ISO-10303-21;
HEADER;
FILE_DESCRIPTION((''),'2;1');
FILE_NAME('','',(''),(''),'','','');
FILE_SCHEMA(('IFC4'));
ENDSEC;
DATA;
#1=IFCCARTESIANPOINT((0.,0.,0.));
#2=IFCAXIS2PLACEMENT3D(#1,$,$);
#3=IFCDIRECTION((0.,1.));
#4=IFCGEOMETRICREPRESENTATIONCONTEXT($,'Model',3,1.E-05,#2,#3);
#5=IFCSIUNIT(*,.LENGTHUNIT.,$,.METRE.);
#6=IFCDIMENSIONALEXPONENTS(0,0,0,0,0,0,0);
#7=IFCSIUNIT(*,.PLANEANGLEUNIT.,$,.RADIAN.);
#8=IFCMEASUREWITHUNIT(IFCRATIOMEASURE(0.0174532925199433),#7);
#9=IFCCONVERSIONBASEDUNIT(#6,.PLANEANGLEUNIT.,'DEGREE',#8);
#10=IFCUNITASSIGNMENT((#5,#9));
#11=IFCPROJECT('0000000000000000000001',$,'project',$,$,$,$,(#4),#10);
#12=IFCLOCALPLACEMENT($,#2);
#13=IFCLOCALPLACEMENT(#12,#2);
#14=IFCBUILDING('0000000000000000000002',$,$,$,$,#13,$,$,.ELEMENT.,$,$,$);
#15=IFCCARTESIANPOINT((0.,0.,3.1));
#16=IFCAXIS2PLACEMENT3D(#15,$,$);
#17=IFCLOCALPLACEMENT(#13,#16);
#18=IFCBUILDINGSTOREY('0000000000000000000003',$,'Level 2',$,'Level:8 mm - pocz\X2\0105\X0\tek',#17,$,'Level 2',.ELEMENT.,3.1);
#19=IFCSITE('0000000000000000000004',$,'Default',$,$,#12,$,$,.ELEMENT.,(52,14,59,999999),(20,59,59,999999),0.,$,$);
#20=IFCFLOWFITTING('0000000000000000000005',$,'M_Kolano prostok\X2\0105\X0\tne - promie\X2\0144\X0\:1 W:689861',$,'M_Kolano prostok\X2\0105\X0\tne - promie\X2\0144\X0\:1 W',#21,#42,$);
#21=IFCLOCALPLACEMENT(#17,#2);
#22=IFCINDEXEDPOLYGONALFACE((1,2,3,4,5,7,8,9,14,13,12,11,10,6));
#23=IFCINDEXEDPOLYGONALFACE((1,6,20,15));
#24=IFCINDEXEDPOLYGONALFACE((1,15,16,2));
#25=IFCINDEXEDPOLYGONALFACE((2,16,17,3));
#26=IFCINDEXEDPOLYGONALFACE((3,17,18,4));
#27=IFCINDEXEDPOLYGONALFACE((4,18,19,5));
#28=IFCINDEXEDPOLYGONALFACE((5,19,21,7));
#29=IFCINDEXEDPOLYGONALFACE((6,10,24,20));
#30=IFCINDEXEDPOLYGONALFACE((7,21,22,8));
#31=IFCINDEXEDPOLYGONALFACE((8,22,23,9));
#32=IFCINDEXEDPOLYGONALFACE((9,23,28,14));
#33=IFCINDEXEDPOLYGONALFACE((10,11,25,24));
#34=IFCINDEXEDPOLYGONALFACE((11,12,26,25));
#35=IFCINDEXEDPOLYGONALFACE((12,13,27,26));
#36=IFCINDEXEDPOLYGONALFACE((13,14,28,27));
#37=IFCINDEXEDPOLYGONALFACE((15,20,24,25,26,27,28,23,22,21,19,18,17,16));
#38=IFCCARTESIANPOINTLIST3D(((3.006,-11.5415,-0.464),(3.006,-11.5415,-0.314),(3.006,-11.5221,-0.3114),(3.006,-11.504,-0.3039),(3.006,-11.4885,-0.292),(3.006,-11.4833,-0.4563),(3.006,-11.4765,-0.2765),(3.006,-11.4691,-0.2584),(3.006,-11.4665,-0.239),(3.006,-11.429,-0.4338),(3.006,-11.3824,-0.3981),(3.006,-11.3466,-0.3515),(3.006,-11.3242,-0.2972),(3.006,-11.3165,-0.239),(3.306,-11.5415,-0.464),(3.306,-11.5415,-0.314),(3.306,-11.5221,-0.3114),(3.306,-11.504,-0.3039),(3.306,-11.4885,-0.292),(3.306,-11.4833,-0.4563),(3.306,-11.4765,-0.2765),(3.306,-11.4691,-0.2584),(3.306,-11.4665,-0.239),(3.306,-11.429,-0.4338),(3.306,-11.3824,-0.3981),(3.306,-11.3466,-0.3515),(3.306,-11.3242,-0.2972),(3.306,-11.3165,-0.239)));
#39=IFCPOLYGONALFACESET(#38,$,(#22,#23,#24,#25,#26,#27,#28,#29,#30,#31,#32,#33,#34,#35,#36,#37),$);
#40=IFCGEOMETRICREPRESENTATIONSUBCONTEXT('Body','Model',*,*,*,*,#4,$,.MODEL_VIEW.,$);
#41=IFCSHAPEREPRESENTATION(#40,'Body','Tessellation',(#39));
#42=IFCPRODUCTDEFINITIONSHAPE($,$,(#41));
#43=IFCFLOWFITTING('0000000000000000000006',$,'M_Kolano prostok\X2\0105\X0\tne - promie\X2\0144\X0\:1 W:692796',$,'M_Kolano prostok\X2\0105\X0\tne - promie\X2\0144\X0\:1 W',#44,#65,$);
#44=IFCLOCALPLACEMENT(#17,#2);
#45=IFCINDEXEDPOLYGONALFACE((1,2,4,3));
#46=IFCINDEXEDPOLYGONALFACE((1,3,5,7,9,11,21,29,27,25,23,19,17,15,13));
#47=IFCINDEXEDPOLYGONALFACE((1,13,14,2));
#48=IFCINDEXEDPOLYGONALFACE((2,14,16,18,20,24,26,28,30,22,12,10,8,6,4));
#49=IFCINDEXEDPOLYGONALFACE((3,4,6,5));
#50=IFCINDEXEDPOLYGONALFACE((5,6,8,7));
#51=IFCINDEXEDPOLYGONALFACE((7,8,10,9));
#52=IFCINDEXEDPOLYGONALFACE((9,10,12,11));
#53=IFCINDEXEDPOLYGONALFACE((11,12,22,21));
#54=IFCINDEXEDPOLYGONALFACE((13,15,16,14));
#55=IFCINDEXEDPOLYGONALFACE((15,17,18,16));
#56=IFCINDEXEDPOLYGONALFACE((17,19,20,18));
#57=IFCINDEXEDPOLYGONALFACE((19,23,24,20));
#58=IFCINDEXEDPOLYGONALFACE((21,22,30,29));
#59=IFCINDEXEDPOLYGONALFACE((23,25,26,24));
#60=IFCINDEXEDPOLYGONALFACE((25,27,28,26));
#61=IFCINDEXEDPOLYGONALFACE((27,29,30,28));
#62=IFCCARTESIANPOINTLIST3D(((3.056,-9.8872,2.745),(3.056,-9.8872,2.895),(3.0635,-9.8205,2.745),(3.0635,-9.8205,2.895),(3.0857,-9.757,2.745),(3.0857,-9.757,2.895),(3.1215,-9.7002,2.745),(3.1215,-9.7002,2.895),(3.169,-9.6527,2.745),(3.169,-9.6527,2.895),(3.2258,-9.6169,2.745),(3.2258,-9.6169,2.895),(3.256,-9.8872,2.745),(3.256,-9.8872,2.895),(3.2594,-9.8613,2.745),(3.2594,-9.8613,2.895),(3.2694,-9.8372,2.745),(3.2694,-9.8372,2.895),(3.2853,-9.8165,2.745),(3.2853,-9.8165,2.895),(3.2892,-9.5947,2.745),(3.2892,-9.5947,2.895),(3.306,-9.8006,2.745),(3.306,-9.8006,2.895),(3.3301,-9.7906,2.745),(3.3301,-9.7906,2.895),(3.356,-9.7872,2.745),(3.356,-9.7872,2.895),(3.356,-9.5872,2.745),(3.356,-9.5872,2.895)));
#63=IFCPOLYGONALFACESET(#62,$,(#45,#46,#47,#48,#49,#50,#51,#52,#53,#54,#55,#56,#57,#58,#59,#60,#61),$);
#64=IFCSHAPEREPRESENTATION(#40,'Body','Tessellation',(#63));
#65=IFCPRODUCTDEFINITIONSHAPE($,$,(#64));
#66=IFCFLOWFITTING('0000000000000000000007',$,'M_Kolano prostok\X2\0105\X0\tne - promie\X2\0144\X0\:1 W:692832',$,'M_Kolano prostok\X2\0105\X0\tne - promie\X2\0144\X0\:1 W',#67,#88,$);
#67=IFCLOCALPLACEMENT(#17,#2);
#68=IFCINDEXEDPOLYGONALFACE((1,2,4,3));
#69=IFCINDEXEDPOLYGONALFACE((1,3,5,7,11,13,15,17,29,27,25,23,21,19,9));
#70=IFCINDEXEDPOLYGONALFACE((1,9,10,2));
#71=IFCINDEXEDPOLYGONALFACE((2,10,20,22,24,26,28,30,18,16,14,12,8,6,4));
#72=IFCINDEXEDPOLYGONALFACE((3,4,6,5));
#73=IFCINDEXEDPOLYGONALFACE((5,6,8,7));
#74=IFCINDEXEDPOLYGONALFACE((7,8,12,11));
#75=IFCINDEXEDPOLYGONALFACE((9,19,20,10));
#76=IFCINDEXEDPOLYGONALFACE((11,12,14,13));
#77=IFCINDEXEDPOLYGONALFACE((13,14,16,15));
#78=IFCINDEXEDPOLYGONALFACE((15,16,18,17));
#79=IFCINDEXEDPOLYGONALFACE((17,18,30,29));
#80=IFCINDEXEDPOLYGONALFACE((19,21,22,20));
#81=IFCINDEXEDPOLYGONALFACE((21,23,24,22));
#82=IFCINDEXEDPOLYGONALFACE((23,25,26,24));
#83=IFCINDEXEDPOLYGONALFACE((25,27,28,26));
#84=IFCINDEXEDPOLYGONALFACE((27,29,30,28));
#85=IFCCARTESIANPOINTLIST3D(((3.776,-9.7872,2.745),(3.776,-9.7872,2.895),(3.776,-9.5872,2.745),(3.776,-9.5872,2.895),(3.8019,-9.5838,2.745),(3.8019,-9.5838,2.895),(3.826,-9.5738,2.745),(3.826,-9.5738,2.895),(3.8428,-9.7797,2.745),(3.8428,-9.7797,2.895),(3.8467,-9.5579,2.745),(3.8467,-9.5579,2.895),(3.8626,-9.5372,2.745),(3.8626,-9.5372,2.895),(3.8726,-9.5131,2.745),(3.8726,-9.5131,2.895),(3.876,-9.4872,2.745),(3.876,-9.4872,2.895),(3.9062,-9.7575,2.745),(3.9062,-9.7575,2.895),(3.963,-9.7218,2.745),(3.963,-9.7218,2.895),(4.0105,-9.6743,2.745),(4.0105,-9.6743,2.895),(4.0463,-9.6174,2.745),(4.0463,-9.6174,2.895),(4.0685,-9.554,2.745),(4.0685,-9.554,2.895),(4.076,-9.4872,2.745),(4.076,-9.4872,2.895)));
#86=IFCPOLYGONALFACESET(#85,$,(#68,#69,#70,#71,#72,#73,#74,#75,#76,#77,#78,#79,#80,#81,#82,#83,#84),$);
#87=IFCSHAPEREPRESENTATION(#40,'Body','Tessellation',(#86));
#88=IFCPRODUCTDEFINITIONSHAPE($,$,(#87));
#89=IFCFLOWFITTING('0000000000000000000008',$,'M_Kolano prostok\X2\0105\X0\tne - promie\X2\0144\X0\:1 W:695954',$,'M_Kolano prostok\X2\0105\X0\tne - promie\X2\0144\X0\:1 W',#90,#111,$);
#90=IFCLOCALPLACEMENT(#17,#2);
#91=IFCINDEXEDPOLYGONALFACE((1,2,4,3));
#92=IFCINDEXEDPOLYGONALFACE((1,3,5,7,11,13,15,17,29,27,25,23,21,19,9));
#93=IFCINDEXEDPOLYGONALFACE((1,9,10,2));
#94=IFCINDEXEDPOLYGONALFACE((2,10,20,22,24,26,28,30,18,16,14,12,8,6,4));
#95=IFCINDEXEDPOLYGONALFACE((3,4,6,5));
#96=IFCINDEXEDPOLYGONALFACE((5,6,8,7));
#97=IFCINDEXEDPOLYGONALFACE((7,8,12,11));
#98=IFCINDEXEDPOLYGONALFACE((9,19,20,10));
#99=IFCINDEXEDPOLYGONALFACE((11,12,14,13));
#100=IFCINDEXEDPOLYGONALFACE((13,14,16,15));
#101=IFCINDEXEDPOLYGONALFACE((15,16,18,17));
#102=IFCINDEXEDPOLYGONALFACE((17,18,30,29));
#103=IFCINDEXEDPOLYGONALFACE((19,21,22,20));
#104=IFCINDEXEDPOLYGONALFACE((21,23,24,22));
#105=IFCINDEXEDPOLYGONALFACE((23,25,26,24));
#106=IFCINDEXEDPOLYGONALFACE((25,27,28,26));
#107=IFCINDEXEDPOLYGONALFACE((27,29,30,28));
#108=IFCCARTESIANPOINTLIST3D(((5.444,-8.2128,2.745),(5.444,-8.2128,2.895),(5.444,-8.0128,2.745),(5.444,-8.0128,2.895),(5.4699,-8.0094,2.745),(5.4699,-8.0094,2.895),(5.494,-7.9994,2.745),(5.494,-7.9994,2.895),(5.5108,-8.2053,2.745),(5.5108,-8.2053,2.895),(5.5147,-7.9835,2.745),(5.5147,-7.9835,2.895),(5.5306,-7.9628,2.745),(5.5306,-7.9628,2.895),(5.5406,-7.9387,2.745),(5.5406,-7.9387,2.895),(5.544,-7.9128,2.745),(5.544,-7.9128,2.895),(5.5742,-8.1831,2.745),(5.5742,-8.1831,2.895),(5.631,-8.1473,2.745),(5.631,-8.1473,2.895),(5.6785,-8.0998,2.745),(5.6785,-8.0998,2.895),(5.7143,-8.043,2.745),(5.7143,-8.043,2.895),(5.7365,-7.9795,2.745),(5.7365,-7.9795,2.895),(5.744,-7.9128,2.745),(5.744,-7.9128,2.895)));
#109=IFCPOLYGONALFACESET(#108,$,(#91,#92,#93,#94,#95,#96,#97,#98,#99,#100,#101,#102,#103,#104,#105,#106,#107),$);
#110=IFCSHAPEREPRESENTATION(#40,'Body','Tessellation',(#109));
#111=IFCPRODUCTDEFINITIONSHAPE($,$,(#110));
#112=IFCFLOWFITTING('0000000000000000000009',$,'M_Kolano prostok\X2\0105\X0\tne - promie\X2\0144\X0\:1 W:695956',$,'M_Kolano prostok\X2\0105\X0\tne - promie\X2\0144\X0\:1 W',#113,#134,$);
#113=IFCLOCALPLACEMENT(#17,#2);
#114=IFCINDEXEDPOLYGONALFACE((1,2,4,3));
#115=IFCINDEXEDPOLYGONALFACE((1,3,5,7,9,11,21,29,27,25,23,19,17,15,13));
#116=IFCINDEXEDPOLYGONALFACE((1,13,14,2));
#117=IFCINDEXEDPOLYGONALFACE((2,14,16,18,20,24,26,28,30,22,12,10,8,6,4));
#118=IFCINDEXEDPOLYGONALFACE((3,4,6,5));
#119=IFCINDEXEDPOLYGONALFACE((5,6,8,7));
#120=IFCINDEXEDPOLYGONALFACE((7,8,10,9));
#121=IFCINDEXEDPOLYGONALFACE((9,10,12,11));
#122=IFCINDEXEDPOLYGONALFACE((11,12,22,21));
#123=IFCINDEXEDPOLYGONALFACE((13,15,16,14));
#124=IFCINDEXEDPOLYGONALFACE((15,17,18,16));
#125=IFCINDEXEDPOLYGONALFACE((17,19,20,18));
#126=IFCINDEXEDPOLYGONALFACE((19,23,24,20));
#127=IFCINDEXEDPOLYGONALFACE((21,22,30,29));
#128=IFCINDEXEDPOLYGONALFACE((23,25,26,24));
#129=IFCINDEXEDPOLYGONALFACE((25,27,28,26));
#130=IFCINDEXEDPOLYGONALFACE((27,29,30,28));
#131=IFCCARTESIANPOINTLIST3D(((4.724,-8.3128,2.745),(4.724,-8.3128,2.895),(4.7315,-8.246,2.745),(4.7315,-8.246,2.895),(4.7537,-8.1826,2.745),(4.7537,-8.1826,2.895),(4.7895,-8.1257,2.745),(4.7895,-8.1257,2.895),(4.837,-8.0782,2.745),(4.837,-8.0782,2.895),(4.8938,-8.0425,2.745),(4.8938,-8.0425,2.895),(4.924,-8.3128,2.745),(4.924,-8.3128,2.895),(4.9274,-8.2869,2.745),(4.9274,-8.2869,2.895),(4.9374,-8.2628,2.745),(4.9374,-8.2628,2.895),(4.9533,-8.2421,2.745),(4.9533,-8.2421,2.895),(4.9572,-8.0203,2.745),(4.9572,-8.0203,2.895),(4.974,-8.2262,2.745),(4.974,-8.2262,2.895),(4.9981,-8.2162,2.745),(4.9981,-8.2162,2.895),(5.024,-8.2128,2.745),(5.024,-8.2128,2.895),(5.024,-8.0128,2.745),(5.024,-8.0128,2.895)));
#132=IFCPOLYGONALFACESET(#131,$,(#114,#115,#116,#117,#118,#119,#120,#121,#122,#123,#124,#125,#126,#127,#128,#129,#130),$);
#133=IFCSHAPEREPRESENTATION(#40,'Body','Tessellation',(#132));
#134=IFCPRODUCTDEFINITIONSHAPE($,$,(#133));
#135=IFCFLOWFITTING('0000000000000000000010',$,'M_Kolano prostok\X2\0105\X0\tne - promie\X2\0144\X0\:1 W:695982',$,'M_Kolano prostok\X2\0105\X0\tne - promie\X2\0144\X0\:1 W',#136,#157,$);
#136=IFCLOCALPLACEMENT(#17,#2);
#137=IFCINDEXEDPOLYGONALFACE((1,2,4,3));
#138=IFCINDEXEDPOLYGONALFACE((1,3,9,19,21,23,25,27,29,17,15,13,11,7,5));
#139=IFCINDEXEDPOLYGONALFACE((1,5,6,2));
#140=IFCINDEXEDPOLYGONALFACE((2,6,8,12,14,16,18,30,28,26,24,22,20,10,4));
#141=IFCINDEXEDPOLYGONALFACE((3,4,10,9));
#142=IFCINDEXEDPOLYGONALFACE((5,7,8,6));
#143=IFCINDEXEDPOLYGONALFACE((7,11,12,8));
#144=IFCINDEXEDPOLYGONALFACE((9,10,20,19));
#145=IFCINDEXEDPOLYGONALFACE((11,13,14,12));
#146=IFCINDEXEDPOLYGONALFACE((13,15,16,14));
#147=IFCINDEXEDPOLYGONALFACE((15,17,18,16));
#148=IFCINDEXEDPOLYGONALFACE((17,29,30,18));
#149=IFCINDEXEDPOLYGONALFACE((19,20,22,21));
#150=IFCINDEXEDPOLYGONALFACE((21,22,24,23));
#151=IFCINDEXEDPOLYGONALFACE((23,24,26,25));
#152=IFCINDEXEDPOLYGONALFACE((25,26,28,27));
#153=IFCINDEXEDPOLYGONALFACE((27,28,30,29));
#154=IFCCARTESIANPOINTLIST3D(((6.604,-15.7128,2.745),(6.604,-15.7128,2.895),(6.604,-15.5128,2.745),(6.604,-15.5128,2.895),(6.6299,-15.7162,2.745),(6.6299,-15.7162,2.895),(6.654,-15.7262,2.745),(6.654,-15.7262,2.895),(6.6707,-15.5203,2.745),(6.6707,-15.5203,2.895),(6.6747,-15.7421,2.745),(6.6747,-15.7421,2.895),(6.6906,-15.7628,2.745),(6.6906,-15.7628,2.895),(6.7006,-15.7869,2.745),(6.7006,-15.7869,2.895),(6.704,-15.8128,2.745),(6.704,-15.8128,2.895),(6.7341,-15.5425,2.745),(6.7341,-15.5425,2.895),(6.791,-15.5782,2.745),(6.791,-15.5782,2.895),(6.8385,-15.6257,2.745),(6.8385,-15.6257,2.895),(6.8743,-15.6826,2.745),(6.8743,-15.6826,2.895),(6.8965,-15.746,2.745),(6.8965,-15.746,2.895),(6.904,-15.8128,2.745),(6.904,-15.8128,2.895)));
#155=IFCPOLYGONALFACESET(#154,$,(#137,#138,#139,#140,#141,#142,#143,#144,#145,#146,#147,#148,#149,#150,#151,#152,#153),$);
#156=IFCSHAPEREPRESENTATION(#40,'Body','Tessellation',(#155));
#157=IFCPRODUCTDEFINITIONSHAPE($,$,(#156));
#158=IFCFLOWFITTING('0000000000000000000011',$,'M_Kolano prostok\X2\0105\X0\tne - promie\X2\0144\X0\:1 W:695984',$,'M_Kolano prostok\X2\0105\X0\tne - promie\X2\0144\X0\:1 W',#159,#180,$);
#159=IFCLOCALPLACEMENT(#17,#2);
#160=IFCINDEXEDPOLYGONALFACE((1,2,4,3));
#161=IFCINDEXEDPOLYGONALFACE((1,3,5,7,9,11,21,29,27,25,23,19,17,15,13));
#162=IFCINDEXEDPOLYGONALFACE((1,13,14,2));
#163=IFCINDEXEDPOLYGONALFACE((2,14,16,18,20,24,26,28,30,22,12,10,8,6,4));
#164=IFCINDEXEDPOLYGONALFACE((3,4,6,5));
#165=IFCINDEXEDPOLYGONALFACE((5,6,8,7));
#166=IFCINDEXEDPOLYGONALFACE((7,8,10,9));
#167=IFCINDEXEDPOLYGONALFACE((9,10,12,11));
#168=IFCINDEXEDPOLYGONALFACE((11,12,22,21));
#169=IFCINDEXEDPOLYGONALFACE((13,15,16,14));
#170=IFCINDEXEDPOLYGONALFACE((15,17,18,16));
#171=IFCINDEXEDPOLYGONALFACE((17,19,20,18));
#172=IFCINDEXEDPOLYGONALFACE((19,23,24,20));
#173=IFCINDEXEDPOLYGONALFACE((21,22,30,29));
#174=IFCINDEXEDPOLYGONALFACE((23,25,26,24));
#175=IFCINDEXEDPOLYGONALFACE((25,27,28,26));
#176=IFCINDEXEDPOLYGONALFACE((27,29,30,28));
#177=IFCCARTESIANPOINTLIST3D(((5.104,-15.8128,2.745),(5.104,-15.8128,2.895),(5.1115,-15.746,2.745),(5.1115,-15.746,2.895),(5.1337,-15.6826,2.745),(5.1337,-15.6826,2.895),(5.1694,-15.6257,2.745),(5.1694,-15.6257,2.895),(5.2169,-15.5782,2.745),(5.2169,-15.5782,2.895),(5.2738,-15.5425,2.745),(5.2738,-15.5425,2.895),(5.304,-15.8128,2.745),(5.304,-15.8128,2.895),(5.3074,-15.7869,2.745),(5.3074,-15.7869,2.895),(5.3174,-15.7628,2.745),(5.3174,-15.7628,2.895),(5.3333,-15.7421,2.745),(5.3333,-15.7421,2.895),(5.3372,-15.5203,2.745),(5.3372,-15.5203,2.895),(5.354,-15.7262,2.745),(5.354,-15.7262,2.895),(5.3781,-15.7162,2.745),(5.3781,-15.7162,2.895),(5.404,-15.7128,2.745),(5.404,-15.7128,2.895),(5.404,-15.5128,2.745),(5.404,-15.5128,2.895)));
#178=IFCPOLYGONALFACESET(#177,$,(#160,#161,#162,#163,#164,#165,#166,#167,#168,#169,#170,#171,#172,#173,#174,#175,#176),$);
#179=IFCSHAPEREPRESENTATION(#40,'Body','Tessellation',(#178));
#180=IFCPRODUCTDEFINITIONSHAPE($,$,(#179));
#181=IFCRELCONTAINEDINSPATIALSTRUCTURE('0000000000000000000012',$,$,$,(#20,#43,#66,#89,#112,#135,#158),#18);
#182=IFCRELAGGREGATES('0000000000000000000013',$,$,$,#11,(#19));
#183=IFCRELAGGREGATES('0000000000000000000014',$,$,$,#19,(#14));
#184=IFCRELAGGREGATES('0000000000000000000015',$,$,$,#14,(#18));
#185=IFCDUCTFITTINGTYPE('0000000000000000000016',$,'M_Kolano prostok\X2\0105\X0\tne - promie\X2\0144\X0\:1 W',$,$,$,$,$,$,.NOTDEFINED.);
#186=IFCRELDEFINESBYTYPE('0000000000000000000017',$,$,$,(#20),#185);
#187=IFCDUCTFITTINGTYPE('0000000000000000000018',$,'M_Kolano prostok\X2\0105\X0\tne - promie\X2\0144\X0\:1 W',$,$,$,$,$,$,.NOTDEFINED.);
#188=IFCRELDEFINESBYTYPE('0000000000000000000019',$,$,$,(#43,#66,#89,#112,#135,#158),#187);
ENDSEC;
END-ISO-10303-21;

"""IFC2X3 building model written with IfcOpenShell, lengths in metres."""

from ifc_helpers import new_model, entity, si_unit, converted_unit, direction, frame, frame_2d, origin, place, context, subcontext, project, spatial, polyline, circle_curve, parameter, trimmed, segment, composite_curve, outline, extrude, source, transform, mapped, type_object, type_shapes, element, save


model = new_model("IFC2X3")

# Units and contexts
model_context = context("Model", 3, precision=1e-05, world=origin(), true_north=direction((0.0, 1.0)))
body_context = subcontext(model_context, "Body", "Model", "MODEL_VIEW")
ifc_project = project(units=[si_unit("LENGTHUNIT", "METRE"), converted_unit("PLANEANGLEUNIT", "DEGREE", entity("IfcRatioMeasure", 0.0174532925199433), si_unit("PLANEANGLEUNIT", "RADIAN"), dimensions=[0, 0, 0, 0, 0, 0, 0])], contexts=[model_context])

# Site, building, storey
site_placement = place(None, origin())
site = spatial("IfcSite", under=ifc_project, at=site_placement, Name="Default", CompositionType="ELEMENT", RefLatitude=(52, 14, 59, 999999), RefLongitude=(20, 59, 59, 999999), RefElevation=0.0)
building_placement = place(site_placement, origin())
building = spatial("IfcBuilding", under=site, at=building_placement, CompositionType="ELEMENT")
storey_placement = place(building_placement, frame((0.0, 0.0, 3.1)))
storey = spatial("IfcBuildingStorey", under=building, at=storey_placement, Name="Level 2", ObjectType="Level:8 mm - początek", LongName="Level 2", CompositionType="ELEMENT", Elevation=3.1)

# Flow fittings
duct_fitting_type_1 = type_object("IfcDuctFittingType", Name="M_Kolano prostokątne - promień:1 W", PredefinedType="NOTDEFINED")
shared_shape_1 = source(origin(), body_context, "Body", "SweptSolid", [
    extrude(outline(composite_curve([segment(polyline([(-0.15, -0.075), (0.0, -0.075)]), True, "CONTINUOUS"), segment(trimmed(circle_curve(frame_2d((0.075, -0.075), x_axis=(0.0, 1.0)), 0.075), [parameter(0.0)], [parameter(90.0)], True, "PARAMETER"), False, "CONTINUOUS"), segment(polyline([(0.075, 0.0), (0.075, 0.15)]), True, "CONTINUOUS"), segment(trimmed(circle_curve(frame_2d((0.075, -0.075), x_axis=(0.0, 1.0)), 0.225), [parameter(0.0)], [parameter(90.0)], True, "PARAMETER"), True, "CONTINUOUS")], self_intersect=False)), frame((-0.075, 0.075, -0.15), z_axis=(0.0, 0.0, 1.0), x_axis=(-1.0, 0.0, 0.0)), (0.0, 0.0, 1.0), 0.3),
])
type_shapes(duct_fitting_type_1, [shared_shape_1])
flow_fitting_1_placement = place(storey_placement, frame((3.156, -11.3915, -0.389), z_axis=(-1.0, 0.0, 0.0), x_axis=(0.0, 0.0, -1.0)))
element("IfcFlowFitting", 1, at=flow_fitting_1_placement, inside=storey, type_object=duct_fitting_type_1, Name="M_Kolano prostokątne - promień:1 W:689861", ObjectType="M_Kolano prostokątne - promień:1 W", context=body_context, shape_type="MappedRepresentation", body=[
    mapped(shared_shape_1, transform((0.0, 0.0, 0.0), scale=1.0)),
])
duct_fitting_type_2 = type_object("IfcDuctFittingType", Name="M_Kolano prostokątne - promień:1 W", PredefinedType="NOTDEFINED")
shared_shape_2 = source(origin(), body_context, "Body", "SweptSolid", [
    extrude(outline(composite_curve([segment(polyline([(-0.2, -0.1), (0.0, -0.1)]), True, "CONTINUOUS"), segment(trimmed(circle_curve(frame_2d((0.1, -0.1), x_axis=(0.0, 1.0)), 0.1), [parameter(0.0)], [parameter(90.0)], True, "PARAMETER"), False, "CONTINUOUS"), segment(polyline([(0.1, 0.0), (0.1, 0.2)]), True, "CONTINUOUS"), segment(trimmed(circle_curve(frame_2d((0.1, -0.1), x_axis=(0.0, 1.0)), 0.3), [parameter(0.0)], [parameter(90.0)], True, "PARAMETER"), True, "CONTINUOUS")], self_intersect=False)), frame((-0.1, 0.1, -0.075), z_axis=(0.0, 0.0, 1.0), x_axis=(-1.0, 0.0, 0.0)), (0.0, 0.0, 1.0), 0.15),
])
type_shapes(duct_fitting_type_2, [shared_shape_2])
flow_fitting_2_placement = place(storey_placement, frame((3.156, -9.6872, 2.82), z_axis=(0.0, 0.0, 1.0), x_axis=(-1.0, 0.0, 0.0)))
element("IfcFlowFitting", 2, at=flow_fitting_2_placement, inside=storey, type_object=duct_fitting_type_2, Name="M_Kolano prostokątne - promień:1 W:692796", ObjectType="M_Kolano prostokątne - promień:1 W", context=body_context, shape_type="MappedRepresentation", body=[
    mapped(shared_shape_2, transform((0.0, 0.0, 0.0), scale=1.0)),
])
for number, where, name in (
    (3, (3.976, -9.6872, 2.82), "M_Kolano prostokątne - promień:1 W:692832"),
    (4, (5.644, -8.1128, 2.82), "M_Kolano prostokątne - promień:1 W:695954"),
):
    element("IfcFlowFitting", number, at=place(storey_placement, frame(where)), inside=storey, type_object=duct_fitting_type_2, Name=name, ObjectType="M_Kolano prostokątne - promień:1 W", context=body_context, shape_type="MappedRepresentation", body=[
        mapped(shared_shape_2, transform((0.0, 0.0, 0.0), scale=1.0)),
    ])
for number, where, z_axis, x_axis, name in (
    (5, (4.824, -8.1128, 2.82), (0.0, 0.0, 1.0), (-1.0, 0.0, 0.0), "M_Kolano prostokątne - promień:1 W:695956"),
    (6, (6.804, -15.6128, 2.82), (0.0, 0.0, 1.0), (0.0, 1.0, 0.0), "M_Kolano prostokątne - promień:1 W:695982"),
    (7, (5.204, -15.6128, 2.82), (0.0, 0.0, 1.0), (-1.0, 0.0, 0.0), "M_Kolano prostokątne - promień:1 W:695984"),
):
    element("IfcFlowFitting", number, at=place(storey_placement, frame(where, z_axis=z_axis, x_axis=x_axis)), inside=storey, type_object=duct_fitting_type_2, Name=name, ObjectType="M_Kolano prostokątne - promień:1 W", context=body_context, shape_type="MappedRepresentation", body=[
        mapped(shared_shape_2, transform((0.0, 0.0, 0.0), scale=1.0)),
    ])

save(model, "model.ifc")
